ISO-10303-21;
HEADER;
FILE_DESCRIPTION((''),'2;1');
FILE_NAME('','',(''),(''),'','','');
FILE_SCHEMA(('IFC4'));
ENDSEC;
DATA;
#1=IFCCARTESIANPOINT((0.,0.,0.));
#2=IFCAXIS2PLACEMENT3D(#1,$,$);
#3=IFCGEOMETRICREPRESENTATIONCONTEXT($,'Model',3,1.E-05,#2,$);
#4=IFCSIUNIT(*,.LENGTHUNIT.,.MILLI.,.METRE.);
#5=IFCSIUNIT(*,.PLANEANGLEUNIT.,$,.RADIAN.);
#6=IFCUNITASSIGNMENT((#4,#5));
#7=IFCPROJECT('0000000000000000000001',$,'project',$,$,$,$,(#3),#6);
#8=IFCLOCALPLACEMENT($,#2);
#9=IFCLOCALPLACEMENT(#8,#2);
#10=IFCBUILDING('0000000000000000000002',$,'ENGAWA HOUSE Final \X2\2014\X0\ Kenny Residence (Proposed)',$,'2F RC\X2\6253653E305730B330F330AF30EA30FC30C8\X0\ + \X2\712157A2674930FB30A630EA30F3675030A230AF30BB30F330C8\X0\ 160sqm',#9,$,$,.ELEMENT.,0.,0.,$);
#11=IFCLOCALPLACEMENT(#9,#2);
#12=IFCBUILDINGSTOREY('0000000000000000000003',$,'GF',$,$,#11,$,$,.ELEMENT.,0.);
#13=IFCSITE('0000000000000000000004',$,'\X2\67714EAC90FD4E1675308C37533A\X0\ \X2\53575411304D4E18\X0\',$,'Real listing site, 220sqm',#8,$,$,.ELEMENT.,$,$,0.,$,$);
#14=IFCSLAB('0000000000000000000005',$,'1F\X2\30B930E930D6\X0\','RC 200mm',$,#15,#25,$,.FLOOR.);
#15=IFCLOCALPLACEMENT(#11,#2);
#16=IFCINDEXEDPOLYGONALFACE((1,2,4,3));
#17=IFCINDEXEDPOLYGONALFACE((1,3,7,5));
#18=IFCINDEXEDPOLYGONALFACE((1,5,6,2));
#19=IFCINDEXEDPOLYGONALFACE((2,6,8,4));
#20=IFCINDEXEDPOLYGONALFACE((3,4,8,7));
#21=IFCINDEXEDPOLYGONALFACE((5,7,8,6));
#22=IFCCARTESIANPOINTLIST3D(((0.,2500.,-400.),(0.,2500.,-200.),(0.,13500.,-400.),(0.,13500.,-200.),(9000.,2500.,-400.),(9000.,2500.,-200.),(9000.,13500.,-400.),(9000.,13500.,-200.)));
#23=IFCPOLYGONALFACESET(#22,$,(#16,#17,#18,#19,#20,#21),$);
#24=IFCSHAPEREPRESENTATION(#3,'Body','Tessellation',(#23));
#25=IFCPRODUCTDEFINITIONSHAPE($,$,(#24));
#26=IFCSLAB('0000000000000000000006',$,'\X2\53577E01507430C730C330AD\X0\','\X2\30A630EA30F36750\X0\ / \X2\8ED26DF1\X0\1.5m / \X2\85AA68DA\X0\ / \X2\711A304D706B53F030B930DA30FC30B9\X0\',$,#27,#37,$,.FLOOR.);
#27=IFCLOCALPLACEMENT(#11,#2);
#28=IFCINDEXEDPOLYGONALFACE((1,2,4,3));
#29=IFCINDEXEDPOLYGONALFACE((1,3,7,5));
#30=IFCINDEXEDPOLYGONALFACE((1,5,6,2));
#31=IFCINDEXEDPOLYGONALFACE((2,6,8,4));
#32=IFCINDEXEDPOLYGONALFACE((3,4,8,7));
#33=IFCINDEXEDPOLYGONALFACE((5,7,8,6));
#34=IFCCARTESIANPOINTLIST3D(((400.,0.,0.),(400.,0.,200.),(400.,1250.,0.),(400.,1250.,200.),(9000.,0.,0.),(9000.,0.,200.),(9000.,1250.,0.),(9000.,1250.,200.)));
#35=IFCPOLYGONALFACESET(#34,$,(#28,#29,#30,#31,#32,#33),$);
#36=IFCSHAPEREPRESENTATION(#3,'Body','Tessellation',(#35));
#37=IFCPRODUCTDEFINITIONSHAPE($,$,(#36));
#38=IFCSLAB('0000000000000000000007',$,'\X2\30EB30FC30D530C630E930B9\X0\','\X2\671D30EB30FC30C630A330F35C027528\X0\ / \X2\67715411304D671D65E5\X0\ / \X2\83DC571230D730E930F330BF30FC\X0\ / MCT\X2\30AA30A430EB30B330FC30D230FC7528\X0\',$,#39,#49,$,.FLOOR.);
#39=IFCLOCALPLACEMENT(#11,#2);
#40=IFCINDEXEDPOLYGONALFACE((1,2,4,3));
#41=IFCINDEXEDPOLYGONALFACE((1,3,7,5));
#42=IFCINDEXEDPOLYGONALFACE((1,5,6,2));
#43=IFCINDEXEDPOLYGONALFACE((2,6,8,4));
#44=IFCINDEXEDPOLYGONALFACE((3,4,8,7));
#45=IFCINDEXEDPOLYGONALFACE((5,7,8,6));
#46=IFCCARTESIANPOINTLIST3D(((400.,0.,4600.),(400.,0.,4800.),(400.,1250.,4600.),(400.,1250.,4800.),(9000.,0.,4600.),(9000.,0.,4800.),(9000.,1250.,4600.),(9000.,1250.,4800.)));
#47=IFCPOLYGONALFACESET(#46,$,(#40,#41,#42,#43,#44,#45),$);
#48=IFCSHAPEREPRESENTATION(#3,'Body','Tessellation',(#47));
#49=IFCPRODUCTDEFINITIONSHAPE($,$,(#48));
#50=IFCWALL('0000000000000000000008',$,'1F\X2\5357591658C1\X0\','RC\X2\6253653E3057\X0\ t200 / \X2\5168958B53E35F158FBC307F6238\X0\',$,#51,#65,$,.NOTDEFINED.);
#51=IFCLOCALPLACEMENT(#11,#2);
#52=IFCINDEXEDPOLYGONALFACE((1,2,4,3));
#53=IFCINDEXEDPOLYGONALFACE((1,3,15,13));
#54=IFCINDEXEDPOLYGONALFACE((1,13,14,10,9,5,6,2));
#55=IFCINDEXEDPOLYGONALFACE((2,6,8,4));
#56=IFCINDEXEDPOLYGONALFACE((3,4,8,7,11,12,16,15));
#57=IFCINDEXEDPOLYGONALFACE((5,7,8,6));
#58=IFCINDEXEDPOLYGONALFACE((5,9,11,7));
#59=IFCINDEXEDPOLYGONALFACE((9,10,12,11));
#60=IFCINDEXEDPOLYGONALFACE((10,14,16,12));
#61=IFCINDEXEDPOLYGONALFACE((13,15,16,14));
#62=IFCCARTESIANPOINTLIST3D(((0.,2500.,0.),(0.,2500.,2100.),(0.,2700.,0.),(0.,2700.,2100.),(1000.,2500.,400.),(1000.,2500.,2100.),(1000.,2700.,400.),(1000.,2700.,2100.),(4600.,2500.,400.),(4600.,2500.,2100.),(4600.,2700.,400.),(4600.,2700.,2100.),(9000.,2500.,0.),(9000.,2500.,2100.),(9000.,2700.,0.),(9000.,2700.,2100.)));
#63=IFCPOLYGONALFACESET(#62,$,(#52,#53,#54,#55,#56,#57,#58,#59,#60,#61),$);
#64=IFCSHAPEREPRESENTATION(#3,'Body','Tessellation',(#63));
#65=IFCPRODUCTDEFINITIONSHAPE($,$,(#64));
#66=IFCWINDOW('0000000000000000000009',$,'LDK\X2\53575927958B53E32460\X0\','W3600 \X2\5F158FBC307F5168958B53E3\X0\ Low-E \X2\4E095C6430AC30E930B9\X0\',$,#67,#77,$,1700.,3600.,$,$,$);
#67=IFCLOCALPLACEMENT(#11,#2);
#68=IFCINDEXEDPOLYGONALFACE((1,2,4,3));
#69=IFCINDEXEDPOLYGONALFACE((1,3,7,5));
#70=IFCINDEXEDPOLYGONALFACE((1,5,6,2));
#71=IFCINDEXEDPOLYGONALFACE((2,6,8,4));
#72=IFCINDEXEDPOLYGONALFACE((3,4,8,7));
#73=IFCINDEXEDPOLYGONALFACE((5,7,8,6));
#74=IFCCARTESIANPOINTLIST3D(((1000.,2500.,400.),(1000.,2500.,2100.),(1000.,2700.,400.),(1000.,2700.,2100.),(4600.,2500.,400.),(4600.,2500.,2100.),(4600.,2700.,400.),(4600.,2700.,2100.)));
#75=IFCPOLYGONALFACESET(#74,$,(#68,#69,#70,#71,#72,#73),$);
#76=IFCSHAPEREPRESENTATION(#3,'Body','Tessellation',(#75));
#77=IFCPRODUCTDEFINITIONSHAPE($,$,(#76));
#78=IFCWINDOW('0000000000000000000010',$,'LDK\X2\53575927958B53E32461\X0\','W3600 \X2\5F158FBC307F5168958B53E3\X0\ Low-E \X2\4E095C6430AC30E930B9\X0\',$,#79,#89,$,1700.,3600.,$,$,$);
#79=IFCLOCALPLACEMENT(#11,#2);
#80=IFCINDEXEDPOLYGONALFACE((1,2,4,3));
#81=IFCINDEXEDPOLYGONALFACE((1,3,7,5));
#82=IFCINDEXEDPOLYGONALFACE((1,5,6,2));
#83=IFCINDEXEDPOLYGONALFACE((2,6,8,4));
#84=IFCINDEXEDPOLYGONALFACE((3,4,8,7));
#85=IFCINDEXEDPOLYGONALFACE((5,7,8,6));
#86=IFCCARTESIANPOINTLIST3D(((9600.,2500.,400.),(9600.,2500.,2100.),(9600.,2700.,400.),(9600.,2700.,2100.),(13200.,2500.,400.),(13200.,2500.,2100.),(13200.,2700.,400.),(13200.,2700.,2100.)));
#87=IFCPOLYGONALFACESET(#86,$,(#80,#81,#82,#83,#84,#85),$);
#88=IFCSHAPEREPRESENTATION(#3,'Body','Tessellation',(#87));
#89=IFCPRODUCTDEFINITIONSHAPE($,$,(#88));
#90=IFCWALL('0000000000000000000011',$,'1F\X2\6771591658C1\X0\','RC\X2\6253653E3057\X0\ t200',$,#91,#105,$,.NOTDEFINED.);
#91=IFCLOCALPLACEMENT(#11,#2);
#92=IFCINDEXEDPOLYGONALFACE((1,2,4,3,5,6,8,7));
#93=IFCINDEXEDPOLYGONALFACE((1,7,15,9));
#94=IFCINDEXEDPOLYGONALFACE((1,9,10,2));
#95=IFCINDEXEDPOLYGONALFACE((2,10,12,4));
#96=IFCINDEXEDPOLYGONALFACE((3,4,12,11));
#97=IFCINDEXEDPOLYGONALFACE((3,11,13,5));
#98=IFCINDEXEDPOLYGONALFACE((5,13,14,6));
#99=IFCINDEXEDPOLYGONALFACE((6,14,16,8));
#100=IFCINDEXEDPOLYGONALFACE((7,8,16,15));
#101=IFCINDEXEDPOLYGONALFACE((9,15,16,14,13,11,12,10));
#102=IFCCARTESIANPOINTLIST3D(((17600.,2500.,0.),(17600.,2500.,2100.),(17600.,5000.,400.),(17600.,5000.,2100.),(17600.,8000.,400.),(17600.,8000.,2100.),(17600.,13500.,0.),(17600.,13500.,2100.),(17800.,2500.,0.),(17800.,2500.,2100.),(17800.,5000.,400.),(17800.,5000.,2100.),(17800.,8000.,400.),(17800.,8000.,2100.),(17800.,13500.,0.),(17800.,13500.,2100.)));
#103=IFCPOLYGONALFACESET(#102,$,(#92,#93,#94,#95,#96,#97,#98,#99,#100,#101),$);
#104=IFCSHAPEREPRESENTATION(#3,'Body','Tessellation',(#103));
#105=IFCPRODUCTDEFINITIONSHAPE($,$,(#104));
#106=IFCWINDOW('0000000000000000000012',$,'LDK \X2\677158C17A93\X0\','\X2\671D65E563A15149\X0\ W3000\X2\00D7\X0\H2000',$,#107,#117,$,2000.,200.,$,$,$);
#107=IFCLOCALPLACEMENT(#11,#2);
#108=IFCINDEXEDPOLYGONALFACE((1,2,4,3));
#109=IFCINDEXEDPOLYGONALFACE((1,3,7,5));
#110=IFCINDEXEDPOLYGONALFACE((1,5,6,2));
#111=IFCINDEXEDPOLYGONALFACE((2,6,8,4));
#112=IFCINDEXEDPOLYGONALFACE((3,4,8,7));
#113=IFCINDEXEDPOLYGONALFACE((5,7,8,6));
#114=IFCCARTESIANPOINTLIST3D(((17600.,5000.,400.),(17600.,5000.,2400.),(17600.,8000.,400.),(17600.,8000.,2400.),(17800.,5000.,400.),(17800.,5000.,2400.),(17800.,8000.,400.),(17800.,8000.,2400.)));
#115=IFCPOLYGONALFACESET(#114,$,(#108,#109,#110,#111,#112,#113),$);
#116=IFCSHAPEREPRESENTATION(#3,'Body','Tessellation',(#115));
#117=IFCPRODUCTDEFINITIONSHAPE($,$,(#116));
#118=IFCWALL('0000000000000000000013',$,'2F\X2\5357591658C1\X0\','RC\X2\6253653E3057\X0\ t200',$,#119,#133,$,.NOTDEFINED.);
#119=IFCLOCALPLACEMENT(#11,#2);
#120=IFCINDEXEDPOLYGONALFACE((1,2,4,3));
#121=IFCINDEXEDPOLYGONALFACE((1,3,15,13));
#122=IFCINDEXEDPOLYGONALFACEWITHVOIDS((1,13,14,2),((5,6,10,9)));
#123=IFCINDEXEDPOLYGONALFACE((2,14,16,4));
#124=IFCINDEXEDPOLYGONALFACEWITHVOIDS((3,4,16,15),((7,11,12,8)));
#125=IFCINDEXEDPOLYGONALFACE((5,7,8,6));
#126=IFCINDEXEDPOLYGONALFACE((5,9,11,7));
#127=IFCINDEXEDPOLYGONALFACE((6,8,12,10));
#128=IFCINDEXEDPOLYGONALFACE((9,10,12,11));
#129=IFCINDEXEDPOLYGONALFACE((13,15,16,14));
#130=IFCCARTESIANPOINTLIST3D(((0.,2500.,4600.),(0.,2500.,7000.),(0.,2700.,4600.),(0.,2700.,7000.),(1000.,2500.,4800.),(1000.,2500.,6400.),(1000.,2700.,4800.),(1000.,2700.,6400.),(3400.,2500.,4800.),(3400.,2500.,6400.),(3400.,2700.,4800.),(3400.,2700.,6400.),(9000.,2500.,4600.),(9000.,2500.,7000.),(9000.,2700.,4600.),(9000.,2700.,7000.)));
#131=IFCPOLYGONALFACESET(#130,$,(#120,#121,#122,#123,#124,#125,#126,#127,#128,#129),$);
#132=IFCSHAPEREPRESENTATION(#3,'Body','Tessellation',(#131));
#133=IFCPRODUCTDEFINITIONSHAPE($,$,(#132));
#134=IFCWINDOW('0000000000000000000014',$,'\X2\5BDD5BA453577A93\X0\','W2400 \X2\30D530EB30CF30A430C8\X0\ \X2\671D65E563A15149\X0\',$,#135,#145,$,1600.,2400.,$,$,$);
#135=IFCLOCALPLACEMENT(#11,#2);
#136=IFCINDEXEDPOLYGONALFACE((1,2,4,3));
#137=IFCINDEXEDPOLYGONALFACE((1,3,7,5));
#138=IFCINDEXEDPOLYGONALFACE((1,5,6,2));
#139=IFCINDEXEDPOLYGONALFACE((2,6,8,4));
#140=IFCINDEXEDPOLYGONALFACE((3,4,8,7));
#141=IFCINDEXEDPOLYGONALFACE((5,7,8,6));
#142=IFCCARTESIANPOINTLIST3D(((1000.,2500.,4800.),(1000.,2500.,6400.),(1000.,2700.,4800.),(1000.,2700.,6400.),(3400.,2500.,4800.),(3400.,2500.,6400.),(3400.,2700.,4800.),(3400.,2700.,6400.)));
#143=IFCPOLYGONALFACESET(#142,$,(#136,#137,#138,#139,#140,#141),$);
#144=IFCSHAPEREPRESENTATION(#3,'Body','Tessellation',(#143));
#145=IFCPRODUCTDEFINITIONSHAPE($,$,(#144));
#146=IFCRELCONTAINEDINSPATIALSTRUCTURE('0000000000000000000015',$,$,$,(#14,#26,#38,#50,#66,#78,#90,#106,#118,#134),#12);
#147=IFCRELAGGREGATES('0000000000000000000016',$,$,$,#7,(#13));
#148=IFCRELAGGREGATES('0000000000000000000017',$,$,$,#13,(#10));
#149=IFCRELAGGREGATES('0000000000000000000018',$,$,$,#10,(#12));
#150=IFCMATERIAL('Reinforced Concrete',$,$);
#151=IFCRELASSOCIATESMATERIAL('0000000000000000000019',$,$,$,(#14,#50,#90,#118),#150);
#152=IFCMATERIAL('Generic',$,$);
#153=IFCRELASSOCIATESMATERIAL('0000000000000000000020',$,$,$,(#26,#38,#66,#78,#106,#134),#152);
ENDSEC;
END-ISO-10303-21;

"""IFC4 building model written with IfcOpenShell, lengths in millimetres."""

from ifc_helpers import new_model, si_unit, frame, frame_2d, origin, place, context, project, spatial, rectangle, extrude, material, element, fill, save


model = new_model("IFC4")

# Units and contexts
model_context = context("Model", 3, precision=1e-05, world=origin())
ifc_project = project(units=[si_unit("LENGTHUNIT", "METRE", prefix="MILLI"), si_unit("PLANEANGLEUNIT", "RADIAN")], contexts=[model_context])

# Site, building, storey
site_placement = place(None, origin())
site = spatial("IfcSite", under=ifc_project, at=site_placement, Name="東京都世田谷区 南向き丘", ObjectType="Real listing site, 220sqm", CompositionType="ELEMENT", RefElevation=0.0)
building_placement = place(site_placement, origin())
building = spatial("IfcBuilding", under=site, at=building_placement, Name="ENGAWA HOUSE Final — Kenny Residence (Proposed)", ObjectType="2F RC打放しコンクリート + 無垢杉・ウリン材アクセント 160sqm", CompositionType="ELEMENT", ElevationOfRefHeight=0.0, ElevationOfTerrain=0.0)
storey_placement = place(building_placement, origin())
storey = spatial("IfcBuildingStorey", under=building, at=storey_placement, Name="GF", CompositionType="ELEMENT", Elevation=0.0)

# Slabs
ifc_material_1 = material(Name="Reinforced Concrete")
slab_1_placement = place(storey_placement, frame((0.0, 1250.0, -200.0)))
element("IfcSlab", 1, at=slab_1_placement, inside=storey, material=ifc_material_1, Name="1Fスラブ", Description="RC 200mm", PredefinedType="FLOOR", context=model_context, shape_type="SweptSolid", body=[
    extrude(rectangle(XDim=9000.0, YDim=11000.0, at=frame_2d((4500.0, 5500.0))), frame((0.0, 1250.0, -200.0)), (0.0, 0.0, 1.0), 200.0),
])
ifc_material_2 = material(Name="Generic")
slab_2_placement = place(storey_placement, frame((200.0, 0.0, 0.0)))
element("IfcSlab", 2, at=slab_2_placement, inside=storey, material=ifc_material_2, Name="南縁側デッキ", Description="ウリン材 / 軒深1.5m / 薪棚 / 焚き火台スペース", PredefinedType="FLOOR", context=model_context, shape_type="SweptSolid", body=[
    extrude(rectangle(XDim=8600.0, YDim=1250.0, at=frame_2d((4300.0, 625.0))), frame((200.0, 0.0, 0.0)), (0.0, 0.0, 1.0), 200.0),
])
slab_3_placement = place(storey_placement, frame((200.0, 0.0, 2300.0)))
element("IfcSlab", 3, at=slab_3_placement, inside=storey, material=ifc_material_2, Name="ルーフテラス", Description="朝ルーティン専用 / 東向き朝日 / 菜園プランター / MCTオイルコーヒー用", PredefinedType="FLOOR", context=model_context, shape_type="SweptSolid", body=[
    extrude(rectangle(XDim=8600.0, YDim=1250.0, at=frame_2d((4300.0, 625.0))), frame((200.0, 0.0, 2300.0)), (0.0, 0.0, 1.0), 200.0),
])

# Wall, openings, windows
wall_1_placement = place(storey_placement, frame((0.0, 1250.0, 0.0)))
wall_1 = element("IfcWall", 4, at=wall_1_placement, inside=storey, material=ifc_material_1, Name="1F南外壁", Description="RC打放し t200 / 全開口引込み戸", PredefinedType="NOTDEFINED", context=model_context, shape_type="SweptSolid", body=[
    extrude(rectangle(XDim=9000.0, YDim=200.0, at=frame_2d((4500.0, 100.0))), frame((0.0, 1250.0, 0.0)), (0.0, 0.0, 1.0), 2100.0),
])
opening_1_placement = place(storey_placement, frame((500.0, 1250.0, 200.0)))
opening_1 = element("IfcOpeningElement", 5, at=opening_1_placement, cuts=wall_1, PredefinedType="NOTDEFINED", context=model_context, shape_type="SweptSolid", body=[
    extrude(rectangle(XDim=3600.0, YDim=200.0, at=frame_2d((1800.0, 100.0))), frame((500.0, 1250.0, 200.0)), (0.0, 0.0, 1.0), 1700.0),
])
opening_2_placement = place(storey_placement, frame((4800.0, 1250.0, 200.0)))
opening_2 = element("IfcOpeningElement", 6, at=opening_2_placement, cuts=wall_1, PredefinedType="NOTDEFINED", context=model_context, shape_type="SweptSolid", body=[
    extrude(rectangle(XDim=3600.0, YDim=200.0, at=frame_2d((1800.0, 100.0))), frame((4800.0, 1250.0, 200.0)), (0.0, 0.0, 1.0), 1700.0),
])
window_1_placement = place(storey_placement, frame((500.0, 1250.0, 200.0)))
window_1 = element("IfcWindow", 7, at=window_1_placement, inside=storey, material=ifc_material_2, Name="LDK南大開口①", Description="W3600 引込み全開口 Low-E 三層ガラス", OverallHeight=1700.0, OverallWidth=3600.0, context=model_context, shape_type="SweptSolid", body=[
    extrude(rectangle(XDim=3600.0, YDim=200.0, at=frame_2d((1800.0, 100.0))), frame((500.0, 1250.0, 200.0)), (0.0, 0.0, 1.0), 1700.0),
])
fill(opening_1, window_1)
window_2_placement = place(storey_placement, frame((4800.0, 1250.0, 200.0)))
window_2 = element("IfcWindow", 8, at=window_2_placement, inside=storey, material=ifc_material_2, Name="LDK南大開口②", Description="W3600 引込み全開口 Low-E 三層ガラス", OverallHeight=1700.0, OverallWidth=3600.0, context=model_context, shape_type="SweptSolid", body=[
    extrude(rectangle(XDim=3600.0, YDim=200.0, at=frame_2d((1800.0, 100.0))), frame((4800.0, 1250.0, 200.0)), (0.0, 0.0, 1.0), 1700.0),
])
fill(opening_2, window_2)

# Wall, opening, window
wall_2_placement = place(storey_placement, frame((8800.0, 1250.0, 0.0)))
wall_2 = element("IfcWall", 9, at=wall_2_placement, inside=storey, material=ifc_material_1, Name="1F東外壁", Description="RC打放し t200", PredefinedType="NOTDEFINED", context=model_context, shape_type="SweptSolid", body=[
    extrude(rectangle(XDim=200.0, YDim=11000.0, at=frame_2d((100.0, 5500.0))), frame((8800.0, 1250.0, 0.0)), (0.0, 0.0, 1.0), 2100.0),
])
opening_3_placement = place(storey_placement, frame((8800.0, 2500.0, 200.0)))
opening_3 = element("IfcOpeningElement", 10, at=opening_3_placement, cuts=wall_2, PredefinedType="NOTDEFINED", context=model_context, shape_type="SweptSolid", body=[
    extrude(rectangle(XDim=200.0, YDim=3000.0, at=frame_2d((100.0, 1500.0))), frame((8800.0, 2500.0, 200.0)), (0.0, 0.0, 1.0), 2000.0),
])
window_3_placement = place(storey_placement, frame((8800.0, 2500.0, 200.0)))
window_3 = element("IfcWindow", 11, at=window_3_placement, inside=storey, material=ifc_material_2, Name="LDK 東壁窓", Description="朝日採光 W3000×H2000", OverallHeight=2000.0, OverallWidth=200.0, context=model_context, shape_type="SweptSolid", body=[
    extrude(rectangle(XDim=200.0, YDim=3000.0, at=frame_2d((100.0, 1500.0))), frame((8800.0, 2500.0, 200.0)), (0.0, 0.0, 1.0), 2000.0),
])
fill(opening_3, window_3)

# Wall, opening, window
wall_3_placement = place(storey_placement, frame((0.0, 1250.0, 2300.0)))
wall_3 = element("IfcWall", 12, at=wall_3_placement, inside=storey, material=ifc_material_1, Name="2F南外壁", Description="RC打放し t200", PredefinedType="NOTDEFINED", context=model_context, shape_type="SweptSolid", body=[
    extrude(rectangle(XDim=9000.0, YDim=200.0, at=frame_2d((4500.0, 100.0))), frame((0.0, 1250.0, 2300.0)), (0.0, 0.0, 1.0), 2400.0),
])
opening_4_placement = place(storey_placement, frame((500.0, 1250.0, 2400.0)))
opening_4 = element("IfcOpeningElement", 13, at=opening_4_placement, cuts=wall_3, PredefinedType="NOTDEFINED", context=model_context, shape_type="SweptSolid", body=[
    extrude(rectangle(XDim=2400.0, YDim=200.0, at=frame_2d((1200.0, 100.0))), frame((500.0, 1250.0, 2400.0)), (0.0, 0.0, 1.0), 1600.0),
])
window_4_placement = place(storey_placement, frame((500.0, 1250.0, 2400.0)))
window_4 = element("IfcWindow", 14, at=window_4_placement, inside=storey, material=ifc_material_2, Name="寝室南窓", Description="W2400 フルハイト 朝日採光", OverallHeight=1600.0, OverallWidth=2400.0, context=model_context, shape_type="SweptSolid", body=[
    extrude(rectangle(XDim=2400.0, YDim=200.0, at=frame_2d((1200.0, 100.0))), frame((500.0, 1250.0, 2400.0)), (0.0, 0.0, 1.0), 1600.0),
])
fill(opening_4, window_4)

save(model, "model.ifc")
